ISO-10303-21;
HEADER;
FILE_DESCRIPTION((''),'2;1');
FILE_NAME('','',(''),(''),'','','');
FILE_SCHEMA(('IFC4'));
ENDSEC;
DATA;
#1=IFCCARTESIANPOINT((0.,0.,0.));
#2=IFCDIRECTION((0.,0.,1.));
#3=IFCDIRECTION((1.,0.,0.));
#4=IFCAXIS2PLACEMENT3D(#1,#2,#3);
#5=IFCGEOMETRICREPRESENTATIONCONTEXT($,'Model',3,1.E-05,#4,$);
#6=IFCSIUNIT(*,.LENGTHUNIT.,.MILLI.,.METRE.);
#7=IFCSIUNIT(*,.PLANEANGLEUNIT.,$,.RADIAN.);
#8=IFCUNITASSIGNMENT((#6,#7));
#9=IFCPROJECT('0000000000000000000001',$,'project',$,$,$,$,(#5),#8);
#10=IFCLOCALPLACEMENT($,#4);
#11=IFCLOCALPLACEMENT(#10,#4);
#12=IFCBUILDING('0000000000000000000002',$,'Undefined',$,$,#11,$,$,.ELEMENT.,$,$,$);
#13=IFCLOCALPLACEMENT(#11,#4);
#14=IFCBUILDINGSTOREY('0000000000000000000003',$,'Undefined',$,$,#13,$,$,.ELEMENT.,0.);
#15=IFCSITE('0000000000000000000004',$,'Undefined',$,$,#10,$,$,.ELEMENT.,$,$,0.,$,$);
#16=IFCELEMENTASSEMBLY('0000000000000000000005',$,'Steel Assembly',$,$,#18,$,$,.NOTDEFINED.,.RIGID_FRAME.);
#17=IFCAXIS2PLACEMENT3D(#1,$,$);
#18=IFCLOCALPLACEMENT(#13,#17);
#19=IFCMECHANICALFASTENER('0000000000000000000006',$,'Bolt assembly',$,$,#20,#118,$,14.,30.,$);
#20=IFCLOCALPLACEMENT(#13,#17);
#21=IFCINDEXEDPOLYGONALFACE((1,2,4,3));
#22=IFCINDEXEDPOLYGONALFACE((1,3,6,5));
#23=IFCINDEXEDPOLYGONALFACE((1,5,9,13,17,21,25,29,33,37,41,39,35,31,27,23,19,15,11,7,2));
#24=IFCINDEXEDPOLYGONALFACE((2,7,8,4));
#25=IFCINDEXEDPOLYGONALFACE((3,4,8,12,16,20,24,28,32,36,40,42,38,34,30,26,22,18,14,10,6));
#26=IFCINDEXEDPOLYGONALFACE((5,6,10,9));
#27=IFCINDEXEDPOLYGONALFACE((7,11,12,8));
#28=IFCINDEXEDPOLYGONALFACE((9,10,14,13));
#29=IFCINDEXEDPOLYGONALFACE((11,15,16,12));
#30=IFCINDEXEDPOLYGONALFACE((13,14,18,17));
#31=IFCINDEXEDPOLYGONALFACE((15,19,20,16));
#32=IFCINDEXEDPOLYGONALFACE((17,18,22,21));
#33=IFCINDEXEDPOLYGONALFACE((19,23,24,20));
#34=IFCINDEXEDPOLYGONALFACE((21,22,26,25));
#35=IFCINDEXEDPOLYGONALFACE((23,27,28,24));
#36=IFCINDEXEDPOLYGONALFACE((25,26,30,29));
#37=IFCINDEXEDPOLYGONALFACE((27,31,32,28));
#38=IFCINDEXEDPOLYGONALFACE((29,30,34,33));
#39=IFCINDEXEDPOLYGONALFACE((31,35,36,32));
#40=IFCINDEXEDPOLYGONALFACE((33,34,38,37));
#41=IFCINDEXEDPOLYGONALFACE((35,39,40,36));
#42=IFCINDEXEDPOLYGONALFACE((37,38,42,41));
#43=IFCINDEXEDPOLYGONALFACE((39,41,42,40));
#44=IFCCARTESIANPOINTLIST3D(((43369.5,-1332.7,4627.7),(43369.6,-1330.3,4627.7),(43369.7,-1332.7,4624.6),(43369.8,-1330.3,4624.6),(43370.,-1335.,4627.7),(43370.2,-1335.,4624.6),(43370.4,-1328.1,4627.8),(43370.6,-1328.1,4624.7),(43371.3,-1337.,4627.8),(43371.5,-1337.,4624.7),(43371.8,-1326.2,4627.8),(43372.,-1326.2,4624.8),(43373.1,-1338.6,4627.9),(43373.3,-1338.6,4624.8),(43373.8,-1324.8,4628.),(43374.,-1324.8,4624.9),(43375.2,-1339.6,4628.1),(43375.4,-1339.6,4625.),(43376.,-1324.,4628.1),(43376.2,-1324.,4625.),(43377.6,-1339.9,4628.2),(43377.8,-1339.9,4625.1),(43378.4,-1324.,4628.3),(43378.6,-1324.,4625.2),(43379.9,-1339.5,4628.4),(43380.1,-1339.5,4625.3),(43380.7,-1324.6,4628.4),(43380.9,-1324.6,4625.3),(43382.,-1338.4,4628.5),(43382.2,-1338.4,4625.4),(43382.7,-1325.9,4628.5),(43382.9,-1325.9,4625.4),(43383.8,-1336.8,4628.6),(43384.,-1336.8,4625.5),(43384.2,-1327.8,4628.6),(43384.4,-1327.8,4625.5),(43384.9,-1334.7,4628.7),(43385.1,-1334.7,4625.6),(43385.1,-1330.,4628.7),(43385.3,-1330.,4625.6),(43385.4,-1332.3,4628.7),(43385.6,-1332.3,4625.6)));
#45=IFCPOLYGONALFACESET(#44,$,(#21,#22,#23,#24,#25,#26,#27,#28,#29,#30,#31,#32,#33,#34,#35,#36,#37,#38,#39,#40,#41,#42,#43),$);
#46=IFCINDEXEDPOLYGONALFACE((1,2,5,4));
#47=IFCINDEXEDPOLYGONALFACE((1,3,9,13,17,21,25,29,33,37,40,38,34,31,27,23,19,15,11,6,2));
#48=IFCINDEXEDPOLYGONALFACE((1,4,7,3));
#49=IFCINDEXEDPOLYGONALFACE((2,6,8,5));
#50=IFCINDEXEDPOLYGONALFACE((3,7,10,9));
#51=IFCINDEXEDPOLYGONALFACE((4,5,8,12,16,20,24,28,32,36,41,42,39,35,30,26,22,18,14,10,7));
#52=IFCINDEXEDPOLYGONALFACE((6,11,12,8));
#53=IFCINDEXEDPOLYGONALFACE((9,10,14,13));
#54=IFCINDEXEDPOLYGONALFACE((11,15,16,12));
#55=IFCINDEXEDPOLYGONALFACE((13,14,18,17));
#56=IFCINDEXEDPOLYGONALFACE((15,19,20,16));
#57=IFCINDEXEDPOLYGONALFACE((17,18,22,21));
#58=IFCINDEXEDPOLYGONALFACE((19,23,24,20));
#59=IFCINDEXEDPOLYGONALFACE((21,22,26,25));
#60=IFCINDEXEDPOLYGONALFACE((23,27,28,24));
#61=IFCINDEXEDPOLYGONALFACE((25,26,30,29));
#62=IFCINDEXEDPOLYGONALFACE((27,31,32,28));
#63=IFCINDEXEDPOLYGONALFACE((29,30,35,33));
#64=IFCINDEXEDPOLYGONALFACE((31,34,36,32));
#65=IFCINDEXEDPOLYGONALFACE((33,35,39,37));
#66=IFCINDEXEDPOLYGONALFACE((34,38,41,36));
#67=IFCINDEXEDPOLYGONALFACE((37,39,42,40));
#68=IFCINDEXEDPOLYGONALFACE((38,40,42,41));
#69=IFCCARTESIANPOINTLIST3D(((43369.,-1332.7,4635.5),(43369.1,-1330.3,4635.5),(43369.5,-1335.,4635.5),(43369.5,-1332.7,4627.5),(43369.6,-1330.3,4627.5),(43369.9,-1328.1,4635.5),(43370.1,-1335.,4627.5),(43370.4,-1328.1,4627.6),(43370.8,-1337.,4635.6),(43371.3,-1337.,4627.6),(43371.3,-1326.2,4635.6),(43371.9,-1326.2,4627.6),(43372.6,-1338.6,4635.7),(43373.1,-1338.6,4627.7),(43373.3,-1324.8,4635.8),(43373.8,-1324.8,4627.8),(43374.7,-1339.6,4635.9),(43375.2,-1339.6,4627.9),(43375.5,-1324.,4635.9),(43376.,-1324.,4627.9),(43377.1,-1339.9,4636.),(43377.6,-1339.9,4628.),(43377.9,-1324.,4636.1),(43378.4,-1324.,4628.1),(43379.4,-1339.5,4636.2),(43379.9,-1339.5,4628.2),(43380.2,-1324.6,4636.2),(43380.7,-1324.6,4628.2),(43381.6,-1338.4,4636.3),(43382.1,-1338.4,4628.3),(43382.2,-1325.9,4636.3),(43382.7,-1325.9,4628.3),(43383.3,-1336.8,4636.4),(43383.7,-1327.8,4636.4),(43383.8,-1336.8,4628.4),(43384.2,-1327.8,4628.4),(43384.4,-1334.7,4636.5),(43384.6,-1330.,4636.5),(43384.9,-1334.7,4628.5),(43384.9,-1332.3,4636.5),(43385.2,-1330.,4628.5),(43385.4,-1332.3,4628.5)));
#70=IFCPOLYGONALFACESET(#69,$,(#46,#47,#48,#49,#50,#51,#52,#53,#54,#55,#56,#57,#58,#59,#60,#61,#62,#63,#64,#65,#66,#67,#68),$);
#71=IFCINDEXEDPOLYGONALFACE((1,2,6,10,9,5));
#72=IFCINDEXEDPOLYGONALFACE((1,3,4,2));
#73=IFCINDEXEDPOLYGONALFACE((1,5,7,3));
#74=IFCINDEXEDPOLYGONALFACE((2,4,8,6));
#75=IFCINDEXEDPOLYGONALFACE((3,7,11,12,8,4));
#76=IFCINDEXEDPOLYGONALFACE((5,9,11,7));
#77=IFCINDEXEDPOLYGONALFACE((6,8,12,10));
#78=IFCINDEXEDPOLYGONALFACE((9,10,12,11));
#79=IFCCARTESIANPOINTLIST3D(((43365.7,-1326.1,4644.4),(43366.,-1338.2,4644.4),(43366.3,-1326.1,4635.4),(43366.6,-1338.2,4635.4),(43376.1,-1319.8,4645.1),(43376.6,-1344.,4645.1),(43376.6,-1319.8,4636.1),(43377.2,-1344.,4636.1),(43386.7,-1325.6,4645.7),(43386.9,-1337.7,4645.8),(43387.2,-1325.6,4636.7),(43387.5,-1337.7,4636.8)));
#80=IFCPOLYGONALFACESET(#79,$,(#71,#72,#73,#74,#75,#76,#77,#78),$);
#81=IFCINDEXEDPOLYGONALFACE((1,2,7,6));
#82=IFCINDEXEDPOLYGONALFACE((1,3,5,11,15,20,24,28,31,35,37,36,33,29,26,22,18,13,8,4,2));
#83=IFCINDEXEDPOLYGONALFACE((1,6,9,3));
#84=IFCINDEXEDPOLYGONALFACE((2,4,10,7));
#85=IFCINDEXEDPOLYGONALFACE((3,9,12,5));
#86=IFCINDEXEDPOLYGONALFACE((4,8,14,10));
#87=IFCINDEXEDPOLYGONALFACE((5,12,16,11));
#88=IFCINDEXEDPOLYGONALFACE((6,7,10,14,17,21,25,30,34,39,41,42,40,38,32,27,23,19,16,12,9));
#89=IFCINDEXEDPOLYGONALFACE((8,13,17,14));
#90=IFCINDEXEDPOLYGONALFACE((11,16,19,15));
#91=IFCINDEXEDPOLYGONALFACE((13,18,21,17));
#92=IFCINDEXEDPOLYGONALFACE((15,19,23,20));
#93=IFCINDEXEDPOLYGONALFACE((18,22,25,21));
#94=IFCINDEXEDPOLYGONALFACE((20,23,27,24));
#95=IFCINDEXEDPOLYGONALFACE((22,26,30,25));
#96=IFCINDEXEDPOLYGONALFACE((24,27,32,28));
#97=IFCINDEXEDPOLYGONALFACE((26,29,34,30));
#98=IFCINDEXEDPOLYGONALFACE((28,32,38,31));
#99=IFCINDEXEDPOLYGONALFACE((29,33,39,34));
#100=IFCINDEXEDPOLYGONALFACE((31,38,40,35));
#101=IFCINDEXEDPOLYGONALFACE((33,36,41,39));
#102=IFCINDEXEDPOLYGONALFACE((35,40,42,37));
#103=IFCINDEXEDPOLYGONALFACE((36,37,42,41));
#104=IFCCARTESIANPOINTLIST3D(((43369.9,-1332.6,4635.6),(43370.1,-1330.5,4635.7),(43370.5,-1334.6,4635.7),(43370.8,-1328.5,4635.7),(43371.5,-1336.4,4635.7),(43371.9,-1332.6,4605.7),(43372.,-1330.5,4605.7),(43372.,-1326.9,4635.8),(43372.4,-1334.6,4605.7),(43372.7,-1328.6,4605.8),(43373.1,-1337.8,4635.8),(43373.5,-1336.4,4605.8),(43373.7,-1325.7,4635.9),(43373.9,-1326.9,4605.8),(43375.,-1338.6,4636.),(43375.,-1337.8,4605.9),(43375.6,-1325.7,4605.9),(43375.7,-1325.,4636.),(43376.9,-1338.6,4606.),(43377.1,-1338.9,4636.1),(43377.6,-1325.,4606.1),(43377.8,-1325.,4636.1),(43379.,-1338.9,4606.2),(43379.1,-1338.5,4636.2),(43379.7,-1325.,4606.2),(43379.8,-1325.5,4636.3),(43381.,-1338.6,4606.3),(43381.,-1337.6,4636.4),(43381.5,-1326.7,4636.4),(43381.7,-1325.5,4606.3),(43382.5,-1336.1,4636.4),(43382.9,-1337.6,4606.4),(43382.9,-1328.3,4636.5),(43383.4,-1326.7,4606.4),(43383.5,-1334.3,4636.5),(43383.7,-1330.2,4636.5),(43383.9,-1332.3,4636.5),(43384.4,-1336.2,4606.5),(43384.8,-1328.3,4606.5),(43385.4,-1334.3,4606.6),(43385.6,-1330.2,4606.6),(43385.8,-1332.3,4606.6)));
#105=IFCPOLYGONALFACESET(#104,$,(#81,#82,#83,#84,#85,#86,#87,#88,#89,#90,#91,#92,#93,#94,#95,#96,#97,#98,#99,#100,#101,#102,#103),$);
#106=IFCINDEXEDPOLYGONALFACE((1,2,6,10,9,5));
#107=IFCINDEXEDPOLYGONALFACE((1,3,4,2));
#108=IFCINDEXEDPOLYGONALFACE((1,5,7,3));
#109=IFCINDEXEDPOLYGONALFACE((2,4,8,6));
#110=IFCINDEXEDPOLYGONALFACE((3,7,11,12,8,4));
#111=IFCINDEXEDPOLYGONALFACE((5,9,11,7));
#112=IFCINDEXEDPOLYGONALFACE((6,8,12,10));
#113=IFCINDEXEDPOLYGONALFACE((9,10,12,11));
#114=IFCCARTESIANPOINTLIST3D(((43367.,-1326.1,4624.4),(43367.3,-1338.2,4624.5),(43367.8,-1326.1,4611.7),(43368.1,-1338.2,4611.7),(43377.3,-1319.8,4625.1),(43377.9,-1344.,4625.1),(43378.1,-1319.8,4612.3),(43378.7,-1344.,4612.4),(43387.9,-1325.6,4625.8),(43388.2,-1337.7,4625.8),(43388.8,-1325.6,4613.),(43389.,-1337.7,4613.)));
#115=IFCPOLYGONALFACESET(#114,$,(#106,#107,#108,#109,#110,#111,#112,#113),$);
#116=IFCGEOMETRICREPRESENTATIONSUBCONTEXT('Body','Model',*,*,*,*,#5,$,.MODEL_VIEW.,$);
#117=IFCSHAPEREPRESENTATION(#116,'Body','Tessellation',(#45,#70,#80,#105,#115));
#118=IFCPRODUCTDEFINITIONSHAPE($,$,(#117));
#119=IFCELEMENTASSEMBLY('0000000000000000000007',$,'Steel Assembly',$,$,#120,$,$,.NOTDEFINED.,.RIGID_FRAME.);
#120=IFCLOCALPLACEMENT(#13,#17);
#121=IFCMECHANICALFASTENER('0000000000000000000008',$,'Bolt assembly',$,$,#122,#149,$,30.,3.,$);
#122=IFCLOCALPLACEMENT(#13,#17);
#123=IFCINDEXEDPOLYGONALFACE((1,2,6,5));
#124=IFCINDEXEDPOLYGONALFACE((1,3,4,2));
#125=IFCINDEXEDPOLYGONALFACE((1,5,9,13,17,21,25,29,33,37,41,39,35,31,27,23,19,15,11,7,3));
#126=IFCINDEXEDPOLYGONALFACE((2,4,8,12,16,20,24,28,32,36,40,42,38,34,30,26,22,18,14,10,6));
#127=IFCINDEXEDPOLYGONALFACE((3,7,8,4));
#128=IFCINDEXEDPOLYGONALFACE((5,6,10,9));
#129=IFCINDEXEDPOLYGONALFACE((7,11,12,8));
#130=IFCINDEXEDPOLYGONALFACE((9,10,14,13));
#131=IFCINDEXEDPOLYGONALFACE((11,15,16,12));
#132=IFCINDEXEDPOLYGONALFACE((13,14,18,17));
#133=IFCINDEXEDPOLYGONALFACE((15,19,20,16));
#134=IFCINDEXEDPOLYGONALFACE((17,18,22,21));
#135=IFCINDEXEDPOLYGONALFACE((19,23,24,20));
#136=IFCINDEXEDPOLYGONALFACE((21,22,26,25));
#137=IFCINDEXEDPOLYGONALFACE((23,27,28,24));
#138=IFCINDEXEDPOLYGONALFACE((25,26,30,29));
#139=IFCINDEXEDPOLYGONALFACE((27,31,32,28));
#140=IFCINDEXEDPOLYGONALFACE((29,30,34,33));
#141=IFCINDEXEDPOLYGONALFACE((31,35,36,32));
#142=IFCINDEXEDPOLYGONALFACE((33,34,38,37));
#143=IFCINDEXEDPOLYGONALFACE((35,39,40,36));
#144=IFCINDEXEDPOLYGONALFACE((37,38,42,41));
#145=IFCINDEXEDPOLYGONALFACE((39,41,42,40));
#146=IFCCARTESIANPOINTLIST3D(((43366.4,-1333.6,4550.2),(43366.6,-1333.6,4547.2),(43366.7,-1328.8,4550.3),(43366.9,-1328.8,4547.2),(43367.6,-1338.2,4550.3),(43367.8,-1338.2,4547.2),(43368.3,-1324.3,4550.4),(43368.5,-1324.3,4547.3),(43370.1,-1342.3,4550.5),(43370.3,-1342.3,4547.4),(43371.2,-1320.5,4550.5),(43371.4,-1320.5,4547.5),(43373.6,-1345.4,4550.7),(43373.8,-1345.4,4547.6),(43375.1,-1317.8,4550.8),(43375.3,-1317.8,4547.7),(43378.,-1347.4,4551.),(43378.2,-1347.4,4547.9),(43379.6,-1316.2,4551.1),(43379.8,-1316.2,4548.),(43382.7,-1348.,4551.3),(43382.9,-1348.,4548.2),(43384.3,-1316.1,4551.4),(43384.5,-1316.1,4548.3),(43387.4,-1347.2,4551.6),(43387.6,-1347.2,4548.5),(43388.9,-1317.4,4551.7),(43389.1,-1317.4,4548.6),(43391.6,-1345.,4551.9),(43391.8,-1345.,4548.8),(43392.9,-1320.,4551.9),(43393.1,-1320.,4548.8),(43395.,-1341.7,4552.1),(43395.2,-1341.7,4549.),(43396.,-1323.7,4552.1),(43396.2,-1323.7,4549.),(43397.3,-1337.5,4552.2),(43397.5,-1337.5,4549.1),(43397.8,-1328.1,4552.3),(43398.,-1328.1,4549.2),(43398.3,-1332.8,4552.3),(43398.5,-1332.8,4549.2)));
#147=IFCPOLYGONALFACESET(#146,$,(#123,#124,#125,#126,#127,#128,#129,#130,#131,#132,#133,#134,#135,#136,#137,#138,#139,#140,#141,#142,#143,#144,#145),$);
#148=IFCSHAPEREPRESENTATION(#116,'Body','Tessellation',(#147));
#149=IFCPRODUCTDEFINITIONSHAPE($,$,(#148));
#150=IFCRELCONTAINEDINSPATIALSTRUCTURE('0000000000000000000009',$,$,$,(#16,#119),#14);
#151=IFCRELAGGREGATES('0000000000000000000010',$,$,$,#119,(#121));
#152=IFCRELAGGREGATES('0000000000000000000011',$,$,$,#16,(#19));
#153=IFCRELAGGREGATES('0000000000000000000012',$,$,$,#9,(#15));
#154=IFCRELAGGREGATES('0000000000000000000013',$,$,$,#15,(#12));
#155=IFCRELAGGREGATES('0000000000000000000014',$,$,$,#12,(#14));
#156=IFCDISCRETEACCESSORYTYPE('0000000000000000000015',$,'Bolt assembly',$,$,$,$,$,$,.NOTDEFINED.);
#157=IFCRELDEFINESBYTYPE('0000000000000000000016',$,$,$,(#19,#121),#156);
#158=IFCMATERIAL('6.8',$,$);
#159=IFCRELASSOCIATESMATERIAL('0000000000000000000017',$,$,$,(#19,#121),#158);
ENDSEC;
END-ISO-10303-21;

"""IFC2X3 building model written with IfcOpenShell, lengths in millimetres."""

from ifc_helpers import new_model, si_unit, frame, origin_with_axes, origin_2d_with_axis, place, context, subcontext, project, spatial, polyline, circle, outline, extrude, source, transform, mapped, material, type_object, element, aggregate, save


model = new_model("IFC2X3")

# Units and contexts
model_context = context("Model", 3, precision=1e-05, world=origin_with_axes())
body_context = subcontext(model_context, "Body", "Model", "MODEL_VIEW")
ifc_project = project(units=[si_unit("LENGTHUNIT", "METRE", prefix="MILLI"), si_unit("PLANEANGLEUNIT", "RADIAN")], contexts=[model_context])

# Site, building, storey
site_placement = place(None, origin_with_axes())
site = spatial("IfcSite", under=ifc_project, at=site_placement, Name="Undefined", CompositionType="ELEMENT", RefElevation=0.0)
building_placement = place(site_placement, origin_with_axes())
building = spatial("IfcBuilding", under=site, at=building_placement, Name="Undefined", CompositionType="ELEMENT")
storey_placement = place(building_placement, origin_with_axes())
storey = spatial("IfcBuildingStorey", under=building, at=storey_placement, Name="Undefined", CompositionType="ELEMENT", Elevation=0.0)

# Element assembly
assembly_1_placement = place(storey_placement, origin_with_axes())
assembly_1 = element("IfcElementAssembly", 1, at=assembly_1_placement, inside=storey, Name="Steel Assembly", AssemblyPlace="NOTDEFINED", PredefinedType="RIGID_FRAME")

# Shared definitions
ifc_material_1 = material(Name="6.8")
discrete_accessory_type_1 = type_object("IfcDiscreteAccessoryType", Name="Bolt assembly")

# Mechanical fastener
shared_shape_1 = source(origin_with_axes(), body_context, "Body", "SweptSolid", [
    extrude(circle(Radius=8.0, at=origin_2d_with_axis()), frame((0.0, 7.8, 0.0), z_axis=(0.0, 1.0, 0.0), x_axis=(1.0, 0.0, 0.0)), (0.0, 0.0, 1.0), 3.1),
    extrude(circle(Radius=8.0, at=origin_2d_with_axis()), frame((0.0, 0.0, 0.0), z_axis=(0.0, 1.0, 0.0), x_axis=(1.0, 0.0, 0.0)), (0.0, 0.0, 1.0), 8.0),
    extrude(outline(polyline([(12.1, 0.0), (6.1, 10.5), (-6.1, 10.5), (-12.1, 0.0), (-6.1, -10.5), (6.1, -10.5), (12.1, 0.0)])), frame((0.0, -9.1, 0.0), z_axis=(0.0, 1.0, 0.0), x_axis=(1.0, 0.0, 0.0)), (0.0, 0.0, 1.0), 9.0),
    extrude(circle(Radius=7.0, at=origin_2d_with_axis()), frame((0.0, -0.1, 0.0), z_axis=(0.0, 1.0, 0.0), x_axis=(1.0, 0.0, 0.0)), (0.0, 0.0, 1.0), 30.0),
    extrude(outline(polyline([(12.1, 0.0), (6.1, 10.5), (-6.1, 10.5), (-12.1, 0.0), (-6.1, -10.5), (6.1, -10.5), (12.1, 0.0)])), frame((0.0, 10.9, 0.0), z_axis=(0.0, 1.0, 0.0), x_axis=(1.0, 0.0, 0.0)), (0.0, 0.0, 1.0), 12.8),
])
mechanical_fastener_1_placement = place(assembly_1_placement, frame((43376.9, -1331.9, 4636.0), z_axis=(0.997704, 0.022685, 0.063821), x_axis=(0.02262, -0.999743, 0.001751)))
mechanical_fastener_1 = element("IfcMechanicalFastener", 2, at=mechanical_fastener_1_placement, type_object=discrete_accessory_type_1, material=ifc_material_1, Name="Bolt assembly", NominalDiameter=14.0, NominalLength=30.0, context=body_context, shape_type="MappedRepresentation", body=[
    mapped(shared_shape_1, transform((0.0, 0.0, 0.0))),
])

# Element assembly, mechanical fastener
assembly_2_placement = place(storey_placement, origin_with_axes())
assembly_2 = element("IfcElementAssembly", 3, at=assembly_2_placement, inside=storey, Name="Steel Assembly", AssemblyPlace="NOTDEFINED", PredefinedType="RIGID_FRAME")
shared_shape_2 = source(origin_with_axes(), body_context, "Body", "SweptSolid", [
    extrude(circle(Radius=16.0, at=origin_2d_with_axis()), frame((0.0, 4.9, 0.0), z_axis=(0.0, 1.0, 0.0), x_axis=(1.0, 0.0, 0.0)), (0.0, 0.0, 1.0), 3.1),
])
mechanical_fastener_2_placement = place(assembly_2_placement, frame((43382.0, -1332.0, 4556.2), z_axis=(0.997704, 0.022685, 0.063821), x_axis=(0.02262, -0.999743, 0.001751)))
mechanical_fastener_2 = element("IfcMechanicalFastener", 4, at=mechanical_fastener_2_placement, type_object=discrete_accessory_type_1, material=ifc_material_1, Name="Bolt assembly", NominalDiameter=30.0, NominalLength=3.0, context=body_context, shape_type="MappedRepresentation", body=[
    mapped(shared_shape_2, transform((0.0, 0.0, 0.0))),
])
aggregate(assembly_2, [mechanical_fastener_2])

aggregate(assembly_1, [mechanical_fastener_1])

save(model, "model.ifc")
